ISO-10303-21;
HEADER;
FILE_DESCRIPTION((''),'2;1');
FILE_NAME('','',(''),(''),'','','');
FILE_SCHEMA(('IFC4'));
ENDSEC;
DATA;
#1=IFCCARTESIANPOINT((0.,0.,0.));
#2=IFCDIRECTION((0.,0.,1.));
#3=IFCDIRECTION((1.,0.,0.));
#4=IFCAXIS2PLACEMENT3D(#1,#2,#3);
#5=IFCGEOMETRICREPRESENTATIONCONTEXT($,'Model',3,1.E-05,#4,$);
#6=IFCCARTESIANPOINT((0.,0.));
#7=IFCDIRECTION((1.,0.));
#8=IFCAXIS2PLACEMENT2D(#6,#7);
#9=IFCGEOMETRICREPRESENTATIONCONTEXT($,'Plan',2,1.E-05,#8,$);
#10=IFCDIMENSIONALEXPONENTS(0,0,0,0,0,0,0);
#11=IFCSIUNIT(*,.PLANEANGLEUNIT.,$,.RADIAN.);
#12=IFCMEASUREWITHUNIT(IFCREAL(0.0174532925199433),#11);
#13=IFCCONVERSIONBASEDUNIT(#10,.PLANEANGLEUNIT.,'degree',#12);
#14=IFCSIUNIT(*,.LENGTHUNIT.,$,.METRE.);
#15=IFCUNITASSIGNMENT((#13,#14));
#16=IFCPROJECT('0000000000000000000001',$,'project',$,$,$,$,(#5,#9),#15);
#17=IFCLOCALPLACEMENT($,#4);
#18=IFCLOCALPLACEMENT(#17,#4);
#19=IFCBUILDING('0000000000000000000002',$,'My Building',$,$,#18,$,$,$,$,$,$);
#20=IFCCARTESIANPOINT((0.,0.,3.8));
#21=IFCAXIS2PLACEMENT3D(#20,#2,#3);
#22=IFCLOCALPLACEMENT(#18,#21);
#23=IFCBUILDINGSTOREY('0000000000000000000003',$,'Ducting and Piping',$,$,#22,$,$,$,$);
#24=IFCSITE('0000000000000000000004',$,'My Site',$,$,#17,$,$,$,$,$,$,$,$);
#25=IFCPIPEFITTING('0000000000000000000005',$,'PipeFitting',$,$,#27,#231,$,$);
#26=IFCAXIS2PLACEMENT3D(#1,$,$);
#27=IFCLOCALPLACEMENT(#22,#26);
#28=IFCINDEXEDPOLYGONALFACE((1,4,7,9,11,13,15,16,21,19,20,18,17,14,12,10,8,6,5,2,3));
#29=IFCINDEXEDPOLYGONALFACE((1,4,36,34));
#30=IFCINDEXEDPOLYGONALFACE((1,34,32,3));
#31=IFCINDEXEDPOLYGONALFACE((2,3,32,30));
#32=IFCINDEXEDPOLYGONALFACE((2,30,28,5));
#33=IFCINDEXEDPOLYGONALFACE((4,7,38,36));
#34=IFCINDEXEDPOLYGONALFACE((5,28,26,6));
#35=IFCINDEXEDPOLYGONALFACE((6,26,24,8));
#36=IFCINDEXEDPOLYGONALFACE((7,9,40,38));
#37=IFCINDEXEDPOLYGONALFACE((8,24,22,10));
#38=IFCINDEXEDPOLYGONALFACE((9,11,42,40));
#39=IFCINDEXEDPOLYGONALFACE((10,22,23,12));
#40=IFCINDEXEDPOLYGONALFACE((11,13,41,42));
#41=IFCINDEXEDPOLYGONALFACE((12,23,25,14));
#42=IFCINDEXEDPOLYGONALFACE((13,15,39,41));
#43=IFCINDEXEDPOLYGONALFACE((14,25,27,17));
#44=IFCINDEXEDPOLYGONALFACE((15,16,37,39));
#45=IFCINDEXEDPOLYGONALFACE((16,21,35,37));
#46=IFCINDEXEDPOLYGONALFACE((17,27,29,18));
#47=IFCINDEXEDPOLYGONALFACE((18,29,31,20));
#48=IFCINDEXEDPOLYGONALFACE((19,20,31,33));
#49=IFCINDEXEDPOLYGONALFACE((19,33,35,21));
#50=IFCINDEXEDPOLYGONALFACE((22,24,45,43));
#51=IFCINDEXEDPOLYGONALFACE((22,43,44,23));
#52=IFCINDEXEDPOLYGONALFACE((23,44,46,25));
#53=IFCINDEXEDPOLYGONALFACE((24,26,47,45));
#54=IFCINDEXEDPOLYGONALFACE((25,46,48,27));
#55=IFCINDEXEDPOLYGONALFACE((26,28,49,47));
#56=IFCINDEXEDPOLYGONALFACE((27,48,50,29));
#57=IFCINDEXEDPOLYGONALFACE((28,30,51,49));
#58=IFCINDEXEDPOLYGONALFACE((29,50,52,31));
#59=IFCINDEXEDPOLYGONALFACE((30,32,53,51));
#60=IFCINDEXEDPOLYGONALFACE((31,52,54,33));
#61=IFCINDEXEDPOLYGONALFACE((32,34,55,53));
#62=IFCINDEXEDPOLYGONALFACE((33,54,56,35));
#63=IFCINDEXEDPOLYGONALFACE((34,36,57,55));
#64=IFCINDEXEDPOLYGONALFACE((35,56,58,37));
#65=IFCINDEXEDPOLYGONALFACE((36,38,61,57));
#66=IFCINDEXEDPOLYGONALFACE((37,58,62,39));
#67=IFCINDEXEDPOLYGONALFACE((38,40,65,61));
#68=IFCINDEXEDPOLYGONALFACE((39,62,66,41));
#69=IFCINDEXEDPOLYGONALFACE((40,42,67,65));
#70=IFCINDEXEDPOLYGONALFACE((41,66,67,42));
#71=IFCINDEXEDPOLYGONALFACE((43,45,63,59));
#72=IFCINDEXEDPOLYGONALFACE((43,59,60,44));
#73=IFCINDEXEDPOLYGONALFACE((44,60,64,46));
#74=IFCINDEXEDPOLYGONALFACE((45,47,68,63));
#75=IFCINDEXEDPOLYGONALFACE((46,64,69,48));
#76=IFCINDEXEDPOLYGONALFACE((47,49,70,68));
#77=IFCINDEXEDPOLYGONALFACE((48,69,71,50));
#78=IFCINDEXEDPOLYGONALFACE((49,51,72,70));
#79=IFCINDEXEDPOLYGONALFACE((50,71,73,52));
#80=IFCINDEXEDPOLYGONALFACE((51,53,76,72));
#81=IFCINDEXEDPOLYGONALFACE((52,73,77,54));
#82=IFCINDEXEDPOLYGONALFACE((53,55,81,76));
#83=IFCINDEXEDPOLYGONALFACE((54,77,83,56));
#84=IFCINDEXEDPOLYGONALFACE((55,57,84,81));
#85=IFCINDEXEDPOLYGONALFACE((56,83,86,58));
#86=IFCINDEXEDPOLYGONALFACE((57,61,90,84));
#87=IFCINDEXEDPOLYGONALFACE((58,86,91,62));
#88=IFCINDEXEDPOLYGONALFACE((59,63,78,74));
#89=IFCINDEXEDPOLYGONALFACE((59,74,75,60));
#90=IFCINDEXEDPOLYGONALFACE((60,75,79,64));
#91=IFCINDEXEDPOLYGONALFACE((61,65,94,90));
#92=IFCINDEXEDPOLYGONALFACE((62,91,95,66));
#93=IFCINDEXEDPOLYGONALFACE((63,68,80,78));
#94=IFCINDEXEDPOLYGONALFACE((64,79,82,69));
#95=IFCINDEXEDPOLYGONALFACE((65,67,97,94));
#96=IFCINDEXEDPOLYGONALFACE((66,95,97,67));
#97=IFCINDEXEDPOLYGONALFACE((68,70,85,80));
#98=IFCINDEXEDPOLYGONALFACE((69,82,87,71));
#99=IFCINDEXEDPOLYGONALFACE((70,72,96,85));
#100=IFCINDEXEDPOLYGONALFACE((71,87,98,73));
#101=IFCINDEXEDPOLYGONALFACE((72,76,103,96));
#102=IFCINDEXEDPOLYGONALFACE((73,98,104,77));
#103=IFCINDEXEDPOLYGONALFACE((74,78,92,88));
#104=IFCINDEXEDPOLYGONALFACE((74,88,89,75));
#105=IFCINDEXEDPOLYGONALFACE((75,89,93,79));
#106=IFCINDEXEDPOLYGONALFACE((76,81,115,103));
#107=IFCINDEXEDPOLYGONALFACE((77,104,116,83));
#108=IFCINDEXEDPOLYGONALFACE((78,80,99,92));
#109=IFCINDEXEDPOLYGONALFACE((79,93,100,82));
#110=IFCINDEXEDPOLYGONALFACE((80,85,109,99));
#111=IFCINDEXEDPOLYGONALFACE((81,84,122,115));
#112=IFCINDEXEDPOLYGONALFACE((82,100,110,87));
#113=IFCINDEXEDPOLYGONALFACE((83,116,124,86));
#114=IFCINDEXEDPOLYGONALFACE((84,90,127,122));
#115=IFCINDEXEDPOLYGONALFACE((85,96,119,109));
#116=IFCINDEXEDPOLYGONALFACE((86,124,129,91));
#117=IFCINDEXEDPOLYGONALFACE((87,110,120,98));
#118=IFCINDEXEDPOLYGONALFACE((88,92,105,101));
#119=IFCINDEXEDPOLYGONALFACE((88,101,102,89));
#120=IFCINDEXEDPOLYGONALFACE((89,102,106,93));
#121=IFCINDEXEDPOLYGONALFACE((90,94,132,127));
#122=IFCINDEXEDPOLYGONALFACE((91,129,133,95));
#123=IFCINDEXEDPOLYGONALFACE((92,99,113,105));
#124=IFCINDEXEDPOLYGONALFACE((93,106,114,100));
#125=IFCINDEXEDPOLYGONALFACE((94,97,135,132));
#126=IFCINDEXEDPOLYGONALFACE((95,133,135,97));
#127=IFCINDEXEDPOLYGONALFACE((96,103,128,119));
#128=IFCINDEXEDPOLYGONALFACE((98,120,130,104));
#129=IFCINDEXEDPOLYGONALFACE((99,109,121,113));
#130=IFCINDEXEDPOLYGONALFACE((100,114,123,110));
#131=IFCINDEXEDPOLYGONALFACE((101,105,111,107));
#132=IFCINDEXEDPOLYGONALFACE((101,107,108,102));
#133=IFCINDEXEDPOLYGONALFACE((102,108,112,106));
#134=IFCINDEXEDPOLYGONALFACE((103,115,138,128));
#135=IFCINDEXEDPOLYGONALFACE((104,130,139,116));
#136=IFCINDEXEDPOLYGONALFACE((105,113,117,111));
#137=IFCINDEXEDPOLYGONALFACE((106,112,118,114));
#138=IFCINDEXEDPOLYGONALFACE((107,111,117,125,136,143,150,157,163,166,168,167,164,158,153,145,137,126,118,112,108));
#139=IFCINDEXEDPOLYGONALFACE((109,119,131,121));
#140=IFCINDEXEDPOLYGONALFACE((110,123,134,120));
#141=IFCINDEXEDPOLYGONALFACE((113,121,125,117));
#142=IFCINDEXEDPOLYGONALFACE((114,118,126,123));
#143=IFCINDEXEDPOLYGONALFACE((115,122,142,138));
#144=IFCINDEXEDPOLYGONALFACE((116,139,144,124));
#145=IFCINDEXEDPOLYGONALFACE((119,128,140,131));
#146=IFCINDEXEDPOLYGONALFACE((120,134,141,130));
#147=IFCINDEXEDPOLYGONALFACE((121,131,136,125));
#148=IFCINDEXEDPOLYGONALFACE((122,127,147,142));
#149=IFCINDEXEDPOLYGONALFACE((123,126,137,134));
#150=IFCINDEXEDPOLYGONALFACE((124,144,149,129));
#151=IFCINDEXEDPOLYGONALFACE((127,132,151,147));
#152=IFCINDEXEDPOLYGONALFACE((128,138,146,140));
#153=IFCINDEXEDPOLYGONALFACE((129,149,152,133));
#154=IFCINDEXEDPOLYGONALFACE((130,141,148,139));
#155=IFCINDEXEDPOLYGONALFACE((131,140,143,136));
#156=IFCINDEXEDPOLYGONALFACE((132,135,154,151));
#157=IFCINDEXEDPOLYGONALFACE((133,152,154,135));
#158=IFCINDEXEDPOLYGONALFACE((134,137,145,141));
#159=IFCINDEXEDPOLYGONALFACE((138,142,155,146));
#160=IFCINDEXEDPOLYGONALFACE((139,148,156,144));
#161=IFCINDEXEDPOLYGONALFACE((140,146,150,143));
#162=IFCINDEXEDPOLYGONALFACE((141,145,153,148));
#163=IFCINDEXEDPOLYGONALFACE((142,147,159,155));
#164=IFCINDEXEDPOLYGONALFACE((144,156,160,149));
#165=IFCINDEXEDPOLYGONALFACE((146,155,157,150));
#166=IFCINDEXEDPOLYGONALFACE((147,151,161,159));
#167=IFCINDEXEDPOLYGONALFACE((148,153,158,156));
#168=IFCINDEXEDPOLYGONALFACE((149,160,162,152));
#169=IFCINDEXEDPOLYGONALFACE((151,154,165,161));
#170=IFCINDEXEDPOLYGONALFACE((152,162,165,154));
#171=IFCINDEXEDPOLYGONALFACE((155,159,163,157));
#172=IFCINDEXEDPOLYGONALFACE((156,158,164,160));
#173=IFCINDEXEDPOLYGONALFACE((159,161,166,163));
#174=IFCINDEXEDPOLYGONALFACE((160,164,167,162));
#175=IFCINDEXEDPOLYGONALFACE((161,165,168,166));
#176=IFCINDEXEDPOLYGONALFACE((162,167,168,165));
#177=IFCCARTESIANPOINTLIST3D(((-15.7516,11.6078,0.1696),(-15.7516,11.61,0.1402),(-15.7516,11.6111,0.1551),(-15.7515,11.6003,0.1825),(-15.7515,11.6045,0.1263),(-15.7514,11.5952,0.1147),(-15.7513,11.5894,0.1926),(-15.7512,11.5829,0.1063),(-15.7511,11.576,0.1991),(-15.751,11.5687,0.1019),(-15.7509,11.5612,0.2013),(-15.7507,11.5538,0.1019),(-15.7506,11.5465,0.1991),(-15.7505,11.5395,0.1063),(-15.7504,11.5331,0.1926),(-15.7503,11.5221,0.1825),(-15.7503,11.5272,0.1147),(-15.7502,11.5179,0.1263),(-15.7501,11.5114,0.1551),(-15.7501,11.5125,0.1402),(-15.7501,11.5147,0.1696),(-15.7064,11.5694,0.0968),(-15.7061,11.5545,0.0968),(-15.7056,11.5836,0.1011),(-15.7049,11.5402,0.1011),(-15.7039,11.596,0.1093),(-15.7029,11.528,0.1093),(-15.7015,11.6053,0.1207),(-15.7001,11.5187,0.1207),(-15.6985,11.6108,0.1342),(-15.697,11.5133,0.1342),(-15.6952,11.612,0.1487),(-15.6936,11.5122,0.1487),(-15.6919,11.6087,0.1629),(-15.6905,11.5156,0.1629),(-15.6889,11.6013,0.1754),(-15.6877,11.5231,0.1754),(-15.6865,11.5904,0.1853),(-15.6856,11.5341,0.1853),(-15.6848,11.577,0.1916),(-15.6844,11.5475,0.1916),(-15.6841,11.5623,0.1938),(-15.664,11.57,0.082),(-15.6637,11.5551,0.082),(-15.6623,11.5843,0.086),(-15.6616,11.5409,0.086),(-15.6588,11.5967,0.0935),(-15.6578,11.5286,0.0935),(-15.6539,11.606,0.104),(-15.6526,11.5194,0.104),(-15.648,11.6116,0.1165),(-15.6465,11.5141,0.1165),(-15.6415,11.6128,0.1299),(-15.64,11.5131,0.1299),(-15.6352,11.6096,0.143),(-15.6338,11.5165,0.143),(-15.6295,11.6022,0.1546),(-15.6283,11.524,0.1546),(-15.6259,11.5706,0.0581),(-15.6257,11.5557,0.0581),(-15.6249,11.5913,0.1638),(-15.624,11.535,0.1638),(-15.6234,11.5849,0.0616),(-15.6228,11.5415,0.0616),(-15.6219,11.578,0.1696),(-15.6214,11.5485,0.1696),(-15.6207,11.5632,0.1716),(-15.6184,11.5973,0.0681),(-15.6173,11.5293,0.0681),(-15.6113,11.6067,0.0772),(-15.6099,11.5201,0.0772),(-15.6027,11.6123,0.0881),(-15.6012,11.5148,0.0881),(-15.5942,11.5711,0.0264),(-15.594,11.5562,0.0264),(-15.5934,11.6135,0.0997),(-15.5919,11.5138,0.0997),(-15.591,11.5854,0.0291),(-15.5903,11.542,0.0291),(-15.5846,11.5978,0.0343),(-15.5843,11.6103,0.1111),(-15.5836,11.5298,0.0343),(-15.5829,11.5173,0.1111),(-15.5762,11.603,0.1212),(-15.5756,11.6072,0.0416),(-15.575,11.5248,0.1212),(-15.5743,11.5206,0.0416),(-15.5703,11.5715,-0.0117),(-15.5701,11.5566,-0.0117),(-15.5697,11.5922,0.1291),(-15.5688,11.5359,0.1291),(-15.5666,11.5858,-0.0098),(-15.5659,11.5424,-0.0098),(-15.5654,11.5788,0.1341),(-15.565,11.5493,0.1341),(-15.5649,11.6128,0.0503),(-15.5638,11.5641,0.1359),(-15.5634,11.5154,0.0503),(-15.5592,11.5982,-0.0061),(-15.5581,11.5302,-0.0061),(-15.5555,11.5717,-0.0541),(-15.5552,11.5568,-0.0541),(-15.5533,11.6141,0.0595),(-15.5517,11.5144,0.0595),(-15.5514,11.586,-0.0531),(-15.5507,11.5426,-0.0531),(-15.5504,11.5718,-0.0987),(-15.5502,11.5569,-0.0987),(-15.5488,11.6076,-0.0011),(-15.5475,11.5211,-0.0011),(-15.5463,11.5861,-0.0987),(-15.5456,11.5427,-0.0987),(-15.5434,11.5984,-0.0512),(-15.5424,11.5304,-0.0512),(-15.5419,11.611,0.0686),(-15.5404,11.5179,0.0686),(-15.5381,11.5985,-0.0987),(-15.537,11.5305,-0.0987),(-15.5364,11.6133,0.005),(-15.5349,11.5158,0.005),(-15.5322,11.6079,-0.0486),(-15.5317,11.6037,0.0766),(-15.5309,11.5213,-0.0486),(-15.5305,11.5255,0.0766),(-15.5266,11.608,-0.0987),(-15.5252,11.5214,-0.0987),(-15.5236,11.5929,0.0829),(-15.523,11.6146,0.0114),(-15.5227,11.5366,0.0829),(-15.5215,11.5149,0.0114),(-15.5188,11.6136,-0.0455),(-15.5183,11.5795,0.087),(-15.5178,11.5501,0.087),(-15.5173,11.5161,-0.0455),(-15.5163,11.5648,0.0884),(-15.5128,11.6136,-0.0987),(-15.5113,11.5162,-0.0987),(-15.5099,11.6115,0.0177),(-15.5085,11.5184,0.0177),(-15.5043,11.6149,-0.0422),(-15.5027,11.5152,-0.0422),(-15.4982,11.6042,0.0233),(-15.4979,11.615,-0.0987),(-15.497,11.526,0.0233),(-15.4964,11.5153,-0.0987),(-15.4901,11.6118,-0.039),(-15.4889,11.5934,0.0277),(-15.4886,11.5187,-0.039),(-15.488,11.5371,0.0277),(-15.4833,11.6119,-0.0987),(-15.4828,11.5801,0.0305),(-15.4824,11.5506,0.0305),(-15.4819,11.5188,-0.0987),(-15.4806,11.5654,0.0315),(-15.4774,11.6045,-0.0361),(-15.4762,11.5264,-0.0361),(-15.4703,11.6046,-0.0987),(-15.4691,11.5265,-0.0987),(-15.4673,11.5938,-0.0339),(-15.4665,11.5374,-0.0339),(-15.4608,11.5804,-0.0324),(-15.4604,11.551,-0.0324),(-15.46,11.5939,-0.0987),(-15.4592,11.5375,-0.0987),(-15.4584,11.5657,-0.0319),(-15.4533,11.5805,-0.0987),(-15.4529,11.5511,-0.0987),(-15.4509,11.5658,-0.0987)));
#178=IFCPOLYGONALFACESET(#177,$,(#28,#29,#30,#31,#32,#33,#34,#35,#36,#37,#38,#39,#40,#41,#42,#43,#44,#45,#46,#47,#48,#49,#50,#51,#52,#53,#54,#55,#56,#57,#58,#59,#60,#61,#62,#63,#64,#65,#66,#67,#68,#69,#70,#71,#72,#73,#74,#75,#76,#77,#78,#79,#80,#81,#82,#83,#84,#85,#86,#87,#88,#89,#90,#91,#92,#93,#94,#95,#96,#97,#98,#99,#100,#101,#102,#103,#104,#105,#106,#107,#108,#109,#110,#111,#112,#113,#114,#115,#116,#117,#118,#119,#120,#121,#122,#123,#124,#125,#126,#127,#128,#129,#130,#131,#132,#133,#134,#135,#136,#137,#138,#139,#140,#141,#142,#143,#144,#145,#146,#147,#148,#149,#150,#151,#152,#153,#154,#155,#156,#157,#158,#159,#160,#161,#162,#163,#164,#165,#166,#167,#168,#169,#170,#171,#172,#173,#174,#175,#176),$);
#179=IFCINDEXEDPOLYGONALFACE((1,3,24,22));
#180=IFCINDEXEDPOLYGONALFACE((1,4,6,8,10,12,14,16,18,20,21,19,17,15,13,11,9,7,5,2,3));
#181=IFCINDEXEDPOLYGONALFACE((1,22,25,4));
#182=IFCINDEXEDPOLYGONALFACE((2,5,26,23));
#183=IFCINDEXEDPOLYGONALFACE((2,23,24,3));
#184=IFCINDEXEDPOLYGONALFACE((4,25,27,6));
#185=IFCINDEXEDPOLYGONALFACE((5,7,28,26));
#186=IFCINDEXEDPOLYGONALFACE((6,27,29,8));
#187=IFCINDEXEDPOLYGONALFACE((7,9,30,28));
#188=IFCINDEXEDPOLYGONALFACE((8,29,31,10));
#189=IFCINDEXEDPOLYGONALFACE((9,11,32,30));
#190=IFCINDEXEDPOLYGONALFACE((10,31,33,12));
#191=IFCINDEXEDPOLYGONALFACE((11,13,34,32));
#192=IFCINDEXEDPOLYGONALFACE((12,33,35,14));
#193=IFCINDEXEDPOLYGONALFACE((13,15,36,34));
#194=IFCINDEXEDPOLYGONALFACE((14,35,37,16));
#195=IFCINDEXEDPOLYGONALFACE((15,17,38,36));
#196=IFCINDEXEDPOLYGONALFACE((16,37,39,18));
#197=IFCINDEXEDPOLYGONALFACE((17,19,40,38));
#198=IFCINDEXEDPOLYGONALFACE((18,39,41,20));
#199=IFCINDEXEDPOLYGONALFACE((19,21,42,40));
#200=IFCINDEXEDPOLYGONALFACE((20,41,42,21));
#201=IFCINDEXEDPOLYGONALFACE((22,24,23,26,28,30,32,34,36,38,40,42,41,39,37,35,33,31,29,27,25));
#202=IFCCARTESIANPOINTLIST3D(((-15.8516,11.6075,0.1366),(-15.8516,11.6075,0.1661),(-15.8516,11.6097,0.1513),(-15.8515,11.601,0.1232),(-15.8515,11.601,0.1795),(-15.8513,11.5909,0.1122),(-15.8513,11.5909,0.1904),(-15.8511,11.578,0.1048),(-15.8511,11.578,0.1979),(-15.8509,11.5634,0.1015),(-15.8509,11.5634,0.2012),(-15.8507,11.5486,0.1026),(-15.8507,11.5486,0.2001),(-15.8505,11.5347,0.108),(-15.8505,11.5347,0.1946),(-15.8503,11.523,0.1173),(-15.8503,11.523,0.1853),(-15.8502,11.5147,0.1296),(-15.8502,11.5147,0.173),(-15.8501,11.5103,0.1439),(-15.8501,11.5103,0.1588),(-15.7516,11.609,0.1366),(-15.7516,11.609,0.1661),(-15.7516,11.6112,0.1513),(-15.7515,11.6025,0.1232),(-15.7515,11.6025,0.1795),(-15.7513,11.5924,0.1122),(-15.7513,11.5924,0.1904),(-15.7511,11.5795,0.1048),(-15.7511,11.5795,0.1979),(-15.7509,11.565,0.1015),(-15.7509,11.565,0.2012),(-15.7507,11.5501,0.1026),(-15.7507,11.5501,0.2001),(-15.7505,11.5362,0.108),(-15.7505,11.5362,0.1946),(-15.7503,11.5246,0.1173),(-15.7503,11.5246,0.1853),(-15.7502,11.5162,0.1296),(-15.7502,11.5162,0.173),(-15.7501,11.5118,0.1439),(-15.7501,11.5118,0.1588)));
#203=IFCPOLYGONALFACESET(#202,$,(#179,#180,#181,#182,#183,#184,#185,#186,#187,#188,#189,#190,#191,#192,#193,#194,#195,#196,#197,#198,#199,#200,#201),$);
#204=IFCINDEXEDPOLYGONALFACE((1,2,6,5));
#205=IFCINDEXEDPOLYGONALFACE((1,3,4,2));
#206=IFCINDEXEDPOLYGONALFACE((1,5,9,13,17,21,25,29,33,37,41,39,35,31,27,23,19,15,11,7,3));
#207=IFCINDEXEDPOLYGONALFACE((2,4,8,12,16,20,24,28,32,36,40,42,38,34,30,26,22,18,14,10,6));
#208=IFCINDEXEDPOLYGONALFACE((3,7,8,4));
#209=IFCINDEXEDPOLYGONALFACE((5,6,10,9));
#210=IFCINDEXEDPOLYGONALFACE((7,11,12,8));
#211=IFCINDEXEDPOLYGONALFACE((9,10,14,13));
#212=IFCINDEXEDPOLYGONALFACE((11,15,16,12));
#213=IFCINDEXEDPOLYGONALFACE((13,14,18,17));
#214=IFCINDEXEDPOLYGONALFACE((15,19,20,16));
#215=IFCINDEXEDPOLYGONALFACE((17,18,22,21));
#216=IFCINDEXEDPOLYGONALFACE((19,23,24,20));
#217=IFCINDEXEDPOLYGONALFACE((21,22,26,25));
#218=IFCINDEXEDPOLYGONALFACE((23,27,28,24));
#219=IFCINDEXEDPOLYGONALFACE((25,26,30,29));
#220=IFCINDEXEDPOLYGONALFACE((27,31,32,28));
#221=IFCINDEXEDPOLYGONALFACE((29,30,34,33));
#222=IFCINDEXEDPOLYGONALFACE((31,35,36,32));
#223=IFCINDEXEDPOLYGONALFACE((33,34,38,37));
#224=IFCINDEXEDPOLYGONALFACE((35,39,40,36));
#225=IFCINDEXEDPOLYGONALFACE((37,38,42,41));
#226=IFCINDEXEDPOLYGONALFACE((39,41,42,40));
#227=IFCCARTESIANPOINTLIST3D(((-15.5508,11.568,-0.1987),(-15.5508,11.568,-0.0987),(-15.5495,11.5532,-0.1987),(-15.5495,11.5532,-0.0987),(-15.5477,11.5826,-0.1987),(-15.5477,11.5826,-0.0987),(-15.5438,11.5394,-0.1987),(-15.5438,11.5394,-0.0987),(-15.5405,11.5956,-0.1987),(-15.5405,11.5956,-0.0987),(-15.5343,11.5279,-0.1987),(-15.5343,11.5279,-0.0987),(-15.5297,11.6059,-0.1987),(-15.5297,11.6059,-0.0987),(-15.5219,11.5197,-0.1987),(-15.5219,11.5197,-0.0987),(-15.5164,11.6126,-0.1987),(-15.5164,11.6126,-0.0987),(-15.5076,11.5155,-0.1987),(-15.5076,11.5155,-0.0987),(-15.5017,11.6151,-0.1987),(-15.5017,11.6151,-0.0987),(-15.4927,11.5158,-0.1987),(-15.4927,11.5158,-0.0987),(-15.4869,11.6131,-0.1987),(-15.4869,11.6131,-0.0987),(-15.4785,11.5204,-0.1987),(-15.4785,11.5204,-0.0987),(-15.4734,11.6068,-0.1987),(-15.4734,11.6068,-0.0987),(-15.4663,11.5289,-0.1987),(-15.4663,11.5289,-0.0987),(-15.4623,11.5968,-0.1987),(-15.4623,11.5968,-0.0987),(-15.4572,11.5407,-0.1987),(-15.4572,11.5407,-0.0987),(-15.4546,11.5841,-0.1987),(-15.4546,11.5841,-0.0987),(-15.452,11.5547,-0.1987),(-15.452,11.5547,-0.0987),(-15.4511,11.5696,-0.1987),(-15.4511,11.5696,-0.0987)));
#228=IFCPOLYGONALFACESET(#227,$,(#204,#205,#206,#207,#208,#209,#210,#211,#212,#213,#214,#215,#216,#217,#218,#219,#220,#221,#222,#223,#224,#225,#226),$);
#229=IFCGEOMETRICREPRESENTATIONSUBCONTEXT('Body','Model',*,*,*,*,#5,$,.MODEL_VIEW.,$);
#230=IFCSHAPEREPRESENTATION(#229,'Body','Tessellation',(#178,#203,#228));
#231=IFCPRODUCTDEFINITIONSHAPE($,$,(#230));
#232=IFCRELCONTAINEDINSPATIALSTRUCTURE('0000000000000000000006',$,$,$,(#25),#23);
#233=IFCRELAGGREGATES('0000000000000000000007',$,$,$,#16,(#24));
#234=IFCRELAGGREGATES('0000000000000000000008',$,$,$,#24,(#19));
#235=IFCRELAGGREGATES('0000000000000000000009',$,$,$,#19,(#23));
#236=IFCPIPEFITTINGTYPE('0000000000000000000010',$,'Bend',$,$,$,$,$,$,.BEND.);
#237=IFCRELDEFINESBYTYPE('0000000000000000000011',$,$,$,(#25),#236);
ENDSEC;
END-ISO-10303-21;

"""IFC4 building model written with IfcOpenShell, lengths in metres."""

from ifc_helpers import new_model, entity, si_unit, converted_unit, frame, origin_with_axes, origin_2d_with_axis, place, context, subcontext, project, spatial, circle, extrude, source, transform, mapped, type_object, type_shapes, element, save


model = new_model("IFC4")

# Units and contexts
model_context = context("Model", 3, precision=1e-05, world=origin_with_axes())
plan_context = context("Plan", 2, precision=1e-05, world=origin_2d_with_axis())
body_context = subcontext(model_context, "Body", "Model", "MODEL_VIEW")
ifc_project = project(units=[converted_unit("PLANEANGLEUNIT", "degree", entity("IfcReal", 0.0174532925199433), si_unit("PLANEANGLEUNIT", "RADIAN"), dimensions=[0, 0, 0, 0, 0, 0, 0]), si_unit("LENGTHUNIT", "METRE")], contexts=[model_context, plan_context])

# Site, building, storey
site_placement = place(None, origin_with_axes())
site = spatial("IfcSite", under=ifc_project, at=site_placement, Name="My Site")
building_placement = place(site_placement, origin_with_axes())
building = spatial("IfcBuilding", under=site, at=building_placement, Name="My Building")
storey_placement = place(building_placement, frame((0.0, 0.0, 3.8), z_axis=(0.0, 0.0, 1.0), x_axis=(1.0, 0.0, 0.0)))
storey = spatial("IfcBuildingStorey", under=building, at=storey_placement, Name="Ducting and Piping")

# Pipe fitting
pipe_fitting_type = type_object("IfcPipeFittingType", Name="Bend", PredefinedType="BEND")
shared_shape = source(origin_with_axes(), body_context, "Body", "SolidModel", [
    entity("IfcSweptDiskSolid", entity("IfcIndexedPolyCurve", entity("IfcCartesianPointList3D", [[0.0, 0.0, 0.1], [0.0, -0.0732, 0.2768], [0.0, -0.25, 0.35]]), [entity("IfcArcIndex", [1, 2, 3])]), 0.05),
    extrude(circle(Radius=0.05), origin_with_axes(), (0.0, 0.0, 1.0), 0.1),
    extrude(circle(Radius=0.05), frame((0.0, -0.25, 0.35), z_axis=(0.0, -1.0, 0.0), x_axis=(1.0, 0.0, 0.0)), (0.0, 0.0, 1.0), 0.1),
])
type_shapes(pipe_fitting_type, [shared_shape])
for number, where, z_axis, x_axis, name in (
    (1, (-15.8508, 11.5597, 0.1513), (0.999882, 0.015371, 0.0), (-0.015371, 0.999882, 0.0), "PipeFitting"),
):
    element("IfcPipeFitting", number, at=place(storey_placement, frame(where, z_axis=z_axis, x_axis=x_axis)), inside=storey, type_object=pipe_fitting_type, Name=name, context=body_context, shape_type="MappedRepresentation", body=[
        mapped(shared_shape, transform((0.0, 0.0, 0.0), x_axis=(1.0, 0.0, 0.0), y_axis=(0.0, 1.0, 0.0), z_axis=(0.0, 0.0, 1.0), scale=1.0)),
    ])

save(model, "model.ifc")
